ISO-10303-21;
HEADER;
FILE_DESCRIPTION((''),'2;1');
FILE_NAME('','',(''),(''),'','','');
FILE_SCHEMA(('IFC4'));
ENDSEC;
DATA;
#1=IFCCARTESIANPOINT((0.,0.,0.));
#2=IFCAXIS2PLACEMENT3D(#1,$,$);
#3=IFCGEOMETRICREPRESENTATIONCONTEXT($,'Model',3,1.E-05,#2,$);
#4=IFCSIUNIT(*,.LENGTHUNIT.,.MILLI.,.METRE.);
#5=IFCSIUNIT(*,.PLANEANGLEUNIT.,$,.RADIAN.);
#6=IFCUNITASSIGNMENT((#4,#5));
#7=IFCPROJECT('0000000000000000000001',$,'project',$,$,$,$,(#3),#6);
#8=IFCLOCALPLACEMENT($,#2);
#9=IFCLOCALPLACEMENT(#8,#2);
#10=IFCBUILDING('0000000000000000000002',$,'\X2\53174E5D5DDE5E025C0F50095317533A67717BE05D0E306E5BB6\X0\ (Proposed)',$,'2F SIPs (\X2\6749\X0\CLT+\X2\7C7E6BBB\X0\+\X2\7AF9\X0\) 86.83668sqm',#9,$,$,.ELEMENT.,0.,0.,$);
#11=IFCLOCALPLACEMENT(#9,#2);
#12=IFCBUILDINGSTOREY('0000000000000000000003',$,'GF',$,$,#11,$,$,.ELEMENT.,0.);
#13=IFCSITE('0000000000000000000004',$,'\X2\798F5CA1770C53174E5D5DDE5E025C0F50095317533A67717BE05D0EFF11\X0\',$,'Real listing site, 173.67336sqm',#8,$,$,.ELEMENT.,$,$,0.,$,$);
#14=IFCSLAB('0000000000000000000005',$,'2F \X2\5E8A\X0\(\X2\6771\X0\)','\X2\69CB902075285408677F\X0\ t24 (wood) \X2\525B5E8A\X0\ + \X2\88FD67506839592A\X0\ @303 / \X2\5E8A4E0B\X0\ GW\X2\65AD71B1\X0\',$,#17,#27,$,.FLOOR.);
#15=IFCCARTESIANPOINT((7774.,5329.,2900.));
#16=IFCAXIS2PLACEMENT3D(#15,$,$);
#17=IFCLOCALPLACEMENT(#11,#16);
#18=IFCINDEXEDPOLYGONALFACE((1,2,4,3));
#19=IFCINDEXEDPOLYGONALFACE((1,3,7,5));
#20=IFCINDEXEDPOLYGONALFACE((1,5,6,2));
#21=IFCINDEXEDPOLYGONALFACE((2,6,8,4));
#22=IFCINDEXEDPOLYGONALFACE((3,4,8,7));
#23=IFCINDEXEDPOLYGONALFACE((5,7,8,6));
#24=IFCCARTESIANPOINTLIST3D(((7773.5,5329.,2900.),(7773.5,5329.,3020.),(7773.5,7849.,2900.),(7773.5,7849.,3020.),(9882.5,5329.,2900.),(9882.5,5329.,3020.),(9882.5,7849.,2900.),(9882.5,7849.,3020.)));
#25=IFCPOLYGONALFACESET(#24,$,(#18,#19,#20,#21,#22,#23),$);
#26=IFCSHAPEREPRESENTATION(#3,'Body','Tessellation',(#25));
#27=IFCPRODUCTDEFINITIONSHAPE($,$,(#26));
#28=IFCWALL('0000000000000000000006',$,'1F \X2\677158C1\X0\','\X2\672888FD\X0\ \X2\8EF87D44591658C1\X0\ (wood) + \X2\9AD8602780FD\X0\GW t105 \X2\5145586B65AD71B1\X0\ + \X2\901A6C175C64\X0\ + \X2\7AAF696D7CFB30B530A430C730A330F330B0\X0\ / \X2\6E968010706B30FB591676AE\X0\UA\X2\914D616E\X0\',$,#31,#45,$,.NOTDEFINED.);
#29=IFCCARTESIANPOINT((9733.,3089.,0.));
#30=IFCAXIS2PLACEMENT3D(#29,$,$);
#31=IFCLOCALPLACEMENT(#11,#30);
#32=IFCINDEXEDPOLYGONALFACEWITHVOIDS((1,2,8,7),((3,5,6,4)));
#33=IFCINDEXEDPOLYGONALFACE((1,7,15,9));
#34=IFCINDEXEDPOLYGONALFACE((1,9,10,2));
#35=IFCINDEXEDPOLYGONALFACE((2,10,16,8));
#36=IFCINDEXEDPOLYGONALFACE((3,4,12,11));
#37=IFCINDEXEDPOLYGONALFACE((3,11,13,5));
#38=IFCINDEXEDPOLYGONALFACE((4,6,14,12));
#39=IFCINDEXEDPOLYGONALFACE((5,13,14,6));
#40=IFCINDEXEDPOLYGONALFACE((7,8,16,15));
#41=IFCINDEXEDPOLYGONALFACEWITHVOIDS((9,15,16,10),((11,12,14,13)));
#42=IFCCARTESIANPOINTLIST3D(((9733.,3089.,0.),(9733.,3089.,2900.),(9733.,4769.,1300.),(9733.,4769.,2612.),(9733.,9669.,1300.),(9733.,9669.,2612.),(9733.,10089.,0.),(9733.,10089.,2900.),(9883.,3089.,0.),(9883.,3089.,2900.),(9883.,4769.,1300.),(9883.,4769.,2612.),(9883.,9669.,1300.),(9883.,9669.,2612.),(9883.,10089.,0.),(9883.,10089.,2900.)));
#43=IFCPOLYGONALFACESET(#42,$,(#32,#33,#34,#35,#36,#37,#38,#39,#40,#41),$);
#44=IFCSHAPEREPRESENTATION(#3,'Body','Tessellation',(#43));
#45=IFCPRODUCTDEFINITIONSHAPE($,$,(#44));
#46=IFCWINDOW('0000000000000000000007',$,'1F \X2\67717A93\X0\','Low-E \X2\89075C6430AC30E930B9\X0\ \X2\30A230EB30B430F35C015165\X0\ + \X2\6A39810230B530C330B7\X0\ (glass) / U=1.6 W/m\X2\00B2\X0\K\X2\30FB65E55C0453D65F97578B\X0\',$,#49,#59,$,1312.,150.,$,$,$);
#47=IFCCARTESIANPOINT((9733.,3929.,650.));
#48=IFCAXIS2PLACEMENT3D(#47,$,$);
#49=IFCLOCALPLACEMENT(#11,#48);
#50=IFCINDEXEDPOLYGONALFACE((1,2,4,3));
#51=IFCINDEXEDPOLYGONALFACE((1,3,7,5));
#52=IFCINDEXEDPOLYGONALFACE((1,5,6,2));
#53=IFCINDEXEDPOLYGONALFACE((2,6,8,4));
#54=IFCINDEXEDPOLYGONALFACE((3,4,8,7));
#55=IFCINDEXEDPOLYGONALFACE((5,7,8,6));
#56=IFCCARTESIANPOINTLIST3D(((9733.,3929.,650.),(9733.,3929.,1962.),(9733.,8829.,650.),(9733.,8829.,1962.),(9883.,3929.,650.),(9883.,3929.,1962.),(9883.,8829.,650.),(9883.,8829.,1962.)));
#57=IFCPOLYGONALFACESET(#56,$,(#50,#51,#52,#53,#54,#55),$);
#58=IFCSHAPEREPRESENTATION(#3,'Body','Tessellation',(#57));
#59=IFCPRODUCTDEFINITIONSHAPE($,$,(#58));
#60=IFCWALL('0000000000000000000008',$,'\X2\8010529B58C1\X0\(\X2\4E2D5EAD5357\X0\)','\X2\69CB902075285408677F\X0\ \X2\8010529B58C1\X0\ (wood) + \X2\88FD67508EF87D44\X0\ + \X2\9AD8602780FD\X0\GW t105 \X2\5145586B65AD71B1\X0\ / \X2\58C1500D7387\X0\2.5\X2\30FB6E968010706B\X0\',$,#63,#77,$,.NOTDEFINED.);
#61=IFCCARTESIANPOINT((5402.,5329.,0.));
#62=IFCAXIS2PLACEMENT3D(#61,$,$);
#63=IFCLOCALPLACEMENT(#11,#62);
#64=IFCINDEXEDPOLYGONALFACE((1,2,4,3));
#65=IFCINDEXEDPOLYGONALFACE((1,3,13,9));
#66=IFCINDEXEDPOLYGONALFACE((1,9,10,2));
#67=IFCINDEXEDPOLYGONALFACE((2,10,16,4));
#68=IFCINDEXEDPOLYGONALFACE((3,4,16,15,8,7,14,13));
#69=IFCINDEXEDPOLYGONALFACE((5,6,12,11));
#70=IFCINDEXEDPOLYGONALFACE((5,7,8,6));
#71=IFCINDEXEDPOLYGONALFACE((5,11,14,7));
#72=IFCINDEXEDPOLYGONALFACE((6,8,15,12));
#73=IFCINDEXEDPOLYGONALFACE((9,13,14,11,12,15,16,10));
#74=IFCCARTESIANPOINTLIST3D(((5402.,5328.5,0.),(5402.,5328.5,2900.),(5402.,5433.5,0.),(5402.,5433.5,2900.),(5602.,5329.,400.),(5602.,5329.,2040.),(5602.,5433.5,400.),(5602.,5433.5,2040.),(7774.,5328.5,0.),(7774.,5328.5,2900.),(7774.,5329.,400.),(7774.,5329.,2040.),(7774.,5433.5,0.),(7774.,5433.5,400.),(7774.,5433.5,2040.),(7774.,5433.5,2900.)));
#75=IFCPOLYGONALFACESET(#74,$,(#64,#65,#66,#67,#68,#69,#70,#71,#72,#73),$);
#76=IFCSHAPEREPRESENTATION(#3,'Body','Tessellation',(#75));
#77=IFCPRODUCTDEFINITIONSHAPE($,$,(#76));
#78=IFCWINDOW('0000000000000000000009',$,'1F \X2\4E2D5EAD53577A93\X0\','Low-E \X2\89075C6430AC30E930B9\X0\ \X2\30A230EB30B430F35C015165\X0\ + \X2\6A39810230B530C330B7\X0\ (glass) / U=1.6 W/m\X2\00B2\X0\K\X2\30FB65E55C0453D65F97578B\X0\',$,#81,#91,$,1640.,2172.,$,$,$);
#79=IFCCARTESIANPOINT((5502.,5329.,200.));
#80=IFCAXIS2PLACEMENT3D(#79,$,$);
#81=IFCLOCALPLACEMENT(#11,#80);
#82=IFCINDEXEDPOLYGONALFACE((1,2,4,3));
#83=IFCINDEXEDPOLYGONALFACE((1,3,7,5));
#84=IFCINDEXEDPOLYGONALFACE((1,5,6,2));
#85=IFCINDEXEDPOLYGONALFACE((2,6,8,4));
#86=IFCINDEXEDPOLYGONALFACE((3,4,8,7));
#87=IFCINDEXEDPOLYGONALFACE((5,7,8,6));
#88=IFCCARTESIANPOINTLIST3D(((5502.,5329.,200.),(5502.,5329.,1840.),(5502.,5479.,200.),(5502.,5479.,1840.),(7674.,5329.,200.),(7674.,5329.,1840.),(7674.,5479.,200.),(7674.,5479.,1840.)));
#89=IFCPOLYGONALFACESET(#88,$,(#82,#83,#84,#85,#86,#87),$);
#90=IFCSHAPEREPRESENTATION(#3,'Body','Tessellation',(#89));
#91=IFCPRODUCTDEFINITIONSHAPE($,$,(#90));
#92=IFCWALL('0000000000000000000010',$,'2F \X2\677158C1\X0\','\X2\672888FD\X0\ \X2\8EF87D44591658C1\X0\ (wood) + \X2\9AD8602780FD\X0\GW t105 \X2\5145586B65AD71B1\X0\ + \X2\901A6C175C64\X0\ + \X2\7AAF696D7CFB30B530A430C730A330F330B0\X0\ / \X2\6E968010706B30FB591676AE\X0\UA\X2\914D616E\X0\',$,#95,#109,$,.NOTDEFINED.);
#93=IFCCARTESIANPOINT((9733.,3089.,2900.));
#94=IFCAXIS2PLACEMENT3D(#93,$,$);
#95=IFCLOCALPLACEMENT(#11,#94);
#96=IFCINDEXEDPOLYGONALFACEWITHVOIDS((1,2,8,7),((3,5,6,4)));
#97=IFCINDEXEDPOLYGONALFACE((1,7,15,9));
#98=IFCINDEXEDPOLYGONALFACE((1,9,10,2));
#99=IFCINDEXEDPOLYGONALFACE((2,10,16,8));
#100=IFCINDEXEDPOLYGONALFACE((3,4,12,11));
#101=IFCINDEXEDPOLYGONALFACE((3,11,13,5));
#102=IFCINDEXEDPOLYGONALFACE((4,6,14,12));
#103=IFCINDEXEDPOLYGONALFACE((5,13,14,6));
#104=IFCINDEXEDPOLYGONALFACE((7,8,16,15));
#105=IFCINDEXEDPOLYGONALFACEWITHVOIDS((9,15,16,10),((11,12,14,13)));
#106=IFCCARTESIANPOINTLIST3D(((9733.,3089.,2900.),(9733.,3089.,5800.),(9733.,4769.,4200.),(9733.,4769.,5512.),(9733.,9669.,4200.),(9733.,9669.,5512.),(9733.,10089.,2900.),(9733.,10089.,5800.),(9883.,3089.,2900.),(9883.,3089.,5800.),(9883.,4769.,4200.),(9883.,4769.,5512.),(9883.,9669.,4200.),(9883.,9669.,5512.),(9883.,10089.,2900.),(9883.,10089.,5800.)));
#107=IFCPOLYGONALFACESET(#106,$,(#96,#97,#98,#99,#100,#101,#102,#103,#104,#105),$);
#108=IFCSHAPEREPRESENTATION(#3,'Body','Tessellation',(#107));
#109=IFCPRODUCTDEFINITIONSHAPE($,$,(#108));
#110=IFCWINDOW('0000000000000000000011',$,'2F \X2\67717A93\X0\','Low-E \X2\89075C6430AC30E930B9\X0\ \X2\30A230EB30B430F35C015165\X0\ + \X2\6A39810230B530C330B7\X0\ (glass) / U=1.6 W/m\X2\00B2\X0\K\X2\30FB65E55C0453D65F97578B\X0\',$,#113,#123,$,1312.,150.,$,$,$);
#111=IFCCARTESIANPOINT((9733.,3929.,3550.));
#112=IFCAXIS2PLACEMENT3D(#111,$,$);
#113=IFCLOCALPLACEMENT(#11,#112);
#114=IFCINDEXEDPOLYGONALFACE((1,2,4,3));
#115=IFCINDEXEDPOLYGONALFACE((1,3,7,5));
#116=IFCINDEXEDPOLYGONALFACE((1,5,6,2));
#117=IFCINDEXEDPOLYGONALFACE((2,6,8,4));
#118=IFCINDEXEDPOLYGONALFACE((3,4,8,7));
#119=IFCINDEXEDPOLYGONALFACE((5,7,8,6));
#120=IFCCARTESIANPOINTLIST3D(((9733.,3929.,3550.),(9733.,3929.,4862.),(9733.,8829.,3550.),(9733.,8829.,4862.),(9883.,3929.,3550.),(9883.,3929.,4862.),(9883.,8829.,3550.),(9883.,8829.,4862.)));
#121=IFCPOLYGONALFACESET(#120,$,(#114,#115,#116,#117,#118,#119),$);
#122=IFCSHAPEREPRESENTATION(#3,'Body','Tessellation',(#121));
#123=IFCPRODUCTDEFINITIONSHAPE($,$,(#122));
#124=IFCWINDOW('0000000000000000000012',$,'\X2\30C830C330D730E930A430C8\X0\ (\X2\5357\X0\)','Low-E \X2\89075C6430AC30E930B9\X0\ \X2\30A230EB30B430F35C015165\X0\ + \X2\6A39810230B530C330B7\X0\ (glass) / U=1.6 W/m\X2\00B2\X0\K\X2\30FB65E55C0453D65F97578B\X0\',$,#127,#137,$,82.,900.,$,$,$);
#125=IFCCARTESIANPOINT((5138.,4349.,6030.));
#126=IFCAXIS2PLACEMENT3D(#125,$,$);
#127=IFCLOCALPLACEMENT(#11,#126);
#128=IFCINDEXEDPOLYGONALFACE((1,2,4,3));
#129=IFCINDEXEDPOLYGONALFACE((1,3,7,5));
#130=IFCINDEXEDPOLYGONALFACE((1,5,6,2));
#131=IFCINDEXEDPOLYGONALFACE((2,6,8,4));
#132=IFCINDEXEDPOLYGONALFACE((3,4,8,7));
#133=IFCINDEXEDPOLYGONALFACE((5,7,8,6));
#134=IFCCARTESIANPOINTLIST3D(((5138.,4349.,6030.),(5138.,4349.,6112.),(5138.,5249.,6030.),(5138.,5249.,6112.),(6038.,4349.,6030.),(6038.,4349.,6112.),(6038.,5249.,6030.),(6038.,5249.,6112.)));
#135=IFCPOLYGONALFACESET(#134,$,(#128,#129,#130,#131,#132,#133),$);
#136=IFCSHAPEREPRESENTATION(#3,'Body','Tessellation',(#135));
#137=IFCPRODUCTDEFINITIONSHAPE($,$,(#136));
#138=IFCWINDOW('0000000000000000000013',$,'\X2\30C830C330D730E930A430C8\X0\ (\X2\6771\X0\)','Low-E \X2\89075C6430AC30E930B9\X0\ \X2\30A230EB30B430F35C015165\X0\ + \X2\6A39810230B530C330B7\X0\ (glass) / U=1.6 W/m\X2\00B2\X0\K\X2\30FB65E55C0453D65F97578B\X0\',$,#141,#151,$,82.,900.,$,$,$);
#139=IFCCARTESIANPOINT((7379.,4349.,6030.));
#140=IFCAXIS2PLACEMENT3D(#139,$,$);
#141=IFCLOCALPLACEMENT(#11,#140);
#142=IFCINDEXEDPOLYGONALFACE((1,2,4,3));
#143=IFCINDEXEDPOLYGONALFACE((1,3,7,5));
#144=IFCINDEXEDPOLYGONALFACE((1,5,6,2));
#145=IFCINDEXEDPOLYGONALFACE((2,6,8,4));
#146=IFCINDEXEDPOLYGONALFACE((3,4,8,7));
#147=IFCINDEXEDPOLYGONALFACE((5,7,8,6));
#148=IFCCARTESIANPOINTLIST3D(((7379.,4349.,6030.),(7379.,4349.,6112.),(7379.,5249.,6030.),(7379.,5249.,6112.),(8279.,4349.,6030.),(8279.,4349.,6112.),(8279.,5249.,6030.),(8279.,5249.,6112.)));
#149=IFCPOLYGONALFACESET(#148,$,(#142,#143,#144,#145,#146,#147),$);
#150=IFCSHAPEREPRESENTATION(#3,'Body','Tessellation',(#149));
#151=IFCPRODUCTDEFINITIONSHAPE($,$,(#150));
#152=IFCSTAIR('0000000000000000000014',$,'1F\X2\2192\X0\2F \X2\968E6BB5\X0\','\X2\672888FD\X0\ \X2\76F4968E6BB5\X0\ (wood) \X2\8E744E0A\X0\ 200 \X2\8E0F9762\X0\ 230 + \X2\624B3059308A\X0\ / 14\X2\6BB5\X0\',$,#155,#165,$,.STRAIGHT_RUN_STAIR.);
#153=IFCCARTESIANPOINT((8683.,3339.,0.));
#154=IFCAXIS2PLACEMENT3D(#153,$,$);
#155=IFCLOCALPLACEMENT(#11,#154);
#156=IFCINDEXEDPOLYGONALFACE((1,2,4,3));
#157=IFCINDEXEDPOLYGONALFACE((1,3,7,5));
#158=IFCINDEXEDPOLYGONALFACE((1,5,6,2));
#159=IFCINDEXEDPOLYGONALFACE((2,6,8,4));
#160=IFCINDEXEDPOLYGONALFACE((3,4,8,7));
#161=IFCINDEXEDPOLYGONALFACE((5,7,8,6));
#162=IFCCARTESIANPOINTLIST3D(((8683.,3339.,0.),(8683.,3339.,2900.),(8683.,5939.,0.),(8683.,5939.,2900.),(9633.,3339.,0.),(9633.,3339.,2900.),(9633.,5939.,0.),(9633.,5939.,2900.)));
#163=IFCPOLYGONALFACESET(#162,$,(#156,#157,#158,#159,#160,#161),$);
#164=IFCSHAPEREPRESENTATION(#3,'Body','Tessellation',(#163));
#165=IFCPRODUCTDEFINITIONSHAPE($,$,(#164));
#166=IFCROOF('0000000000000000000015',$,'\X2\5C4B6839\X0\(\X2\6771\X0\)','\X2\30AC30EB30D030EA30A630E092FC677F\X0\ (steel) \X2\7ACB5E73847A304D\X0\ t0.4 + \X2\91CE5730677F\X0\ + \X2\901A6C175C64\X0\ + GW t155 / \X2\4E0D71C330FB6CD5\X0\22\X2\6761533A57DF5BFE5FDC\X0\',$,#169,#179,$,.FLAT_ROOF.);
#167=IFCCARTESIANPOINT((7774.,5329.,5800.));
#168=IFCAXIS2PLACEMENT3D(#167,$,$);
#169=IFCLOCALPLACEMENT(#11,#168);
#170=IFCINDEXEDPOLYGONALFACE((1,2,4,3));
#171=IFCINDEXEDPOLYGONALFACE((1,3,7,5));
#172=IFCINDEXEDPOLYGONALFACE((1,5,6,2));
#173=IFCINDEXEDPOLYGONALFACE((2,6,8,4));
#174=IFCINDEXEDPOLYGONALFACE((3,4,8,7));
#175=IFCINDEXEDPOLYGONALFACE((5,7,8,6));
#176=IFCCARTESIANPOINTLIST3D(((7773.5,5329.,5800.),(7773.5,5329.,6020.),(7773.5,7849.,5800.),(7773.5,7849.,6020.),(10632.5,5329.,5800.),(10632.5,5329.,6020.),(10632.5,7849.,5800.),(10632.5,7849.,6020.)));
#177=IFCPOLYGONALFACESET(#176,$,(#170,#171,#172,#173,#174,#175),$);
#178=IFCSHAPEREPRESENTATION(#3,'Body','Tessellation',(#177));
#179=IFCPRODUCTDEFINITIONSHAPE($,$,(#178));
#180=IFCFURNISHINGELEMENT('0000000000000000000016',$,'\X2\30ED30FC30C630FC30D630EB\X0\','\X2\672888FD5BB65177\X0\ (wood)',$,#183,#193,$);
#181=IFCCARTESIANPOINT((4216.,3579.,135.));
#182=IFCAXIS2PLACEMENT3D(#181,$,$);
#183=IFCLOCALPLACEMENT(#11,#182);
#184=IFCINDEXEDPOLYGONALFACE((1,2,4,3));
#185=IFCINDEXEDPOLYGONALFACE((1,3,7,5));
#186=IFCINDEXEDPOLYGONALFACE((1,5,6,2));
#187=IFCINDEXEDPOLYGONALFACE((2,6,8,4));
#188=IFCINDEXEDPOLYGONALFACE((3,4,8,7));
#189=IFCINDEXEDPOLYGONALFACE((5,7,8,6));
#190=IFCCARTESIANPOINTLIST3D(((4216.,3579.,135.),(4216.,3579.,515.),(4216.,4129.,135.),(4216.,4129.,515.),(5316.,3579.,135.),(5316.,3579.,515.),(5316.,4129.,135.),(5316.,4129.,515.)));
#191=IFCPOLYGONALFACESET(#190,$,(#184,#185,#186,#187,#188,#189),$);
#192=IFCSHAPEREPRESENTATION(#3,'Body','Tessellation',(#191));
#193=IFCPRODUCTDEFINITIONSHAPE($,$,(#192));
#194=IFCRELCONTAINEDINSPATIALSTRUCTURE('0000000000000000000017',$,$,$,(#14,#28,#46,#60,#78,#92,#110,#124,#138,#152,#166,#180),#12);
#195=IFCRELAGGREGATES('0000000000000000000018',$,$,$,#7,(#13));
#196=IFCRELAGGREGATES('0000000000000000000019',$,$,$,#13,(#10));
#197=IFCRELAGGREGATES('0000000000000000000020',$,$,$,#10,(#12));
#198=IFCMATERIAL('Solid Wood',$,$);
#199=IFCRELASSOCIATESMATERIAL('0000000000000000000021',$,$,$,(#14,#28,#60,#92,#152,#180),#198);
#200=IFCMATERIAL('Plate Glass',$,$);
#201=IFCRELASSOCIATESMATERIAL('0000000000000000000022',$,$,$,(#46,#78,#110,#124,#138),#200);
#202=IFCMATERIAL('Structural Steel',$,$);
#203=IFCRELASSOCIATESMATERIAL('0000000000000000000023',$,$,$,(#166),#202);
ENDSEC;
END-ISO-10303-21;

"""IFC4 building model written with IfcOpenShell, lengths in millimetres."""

from ifc_helpers import new_model, si_unit, frame, frame_2d, origin, place, context, project, spatial, rectangle, extrude, material, element, fill, save


model = new_model("IFC4")

# Units and contexts
model_context = context("Model", 3, precision=1e-05, world=origin())
ifc_project = project(units=[si_unit("LENGTHUNIT", "METRE", prefix="MILLI"), si_unit("PLANEANGLEUNIT", "RADIAN")], contexts=[model_context])

# Site, building, storey
site_placement = place(None, origin())
site = spatial("IfcSite", under=ifc_project, at=site_placement, Name="福岡県北九州市小倉北区東篠崎１", ObjectType="Real listing site, 173.67336sqm", CompositionType="ELEMENT", RefElevation=0.0)
building_placement = place(site_placement, origin())
building = spatial("IfcBuilding", under=site, at=building_placement, Name="北九州市小倉北区東篠崎の家 (Proposed)", ObjectType="2F SIPs (杉CLT+籾殻+竹) 86.83668sqm", CompositionType="ELEMENT", ElevationOfRefHeight=0.0, ElevationOfTerrain=0.0)
storey_placement = place(building_placement, origin())
storey = spatial("IfcBuildingStorey", under=building, at=storey_placement, Name="GF", CompositionType="ELEMENT", Elevation=0.0)

# Slab
ifc_material_1 = material(Name="Solid Wood")
slab_1_placement = place(storey_placement, frame((7774.0, 5329.0, 2900.0)))
element("IfcSlab", 1, at=slab_1_placement, inside=storey, material=ifc_material_1, Name="2F 床(東)", Description="構造用合板 t24 (wood) 剛床 + 製材根太 @303 / 床下 GW断熱", PredefinedType="FLOOR", context=model_context, shape_type="SweptSolid", body=[
    extrude(rectangle(XDim=2109.0, YDim=2520.0, at=frame_2d((1054.0, 1260.0))), frame((7774.0, 5329.0, 2900.0)), (0.0, 0.0, 1.0), 120.0),
])

# Walls, openings, windows
wall_1_placement = place(storey_placement, frame((9733.0, 3089.0, 0.0)))
wall_1 = element("IfcWall", 2, at=wall_1_placement, inside=storey, material=ifc_material_1, Name="1F 東壁", Description="木製 軸組外壁 (wood) + 高性能GW t105 充填断熱 + 通気層 + 窯業系サイディング / 準耐火・外皮UA配慮", PredefinedType="NOTDEFINED", context=model_context, shape_type="SweptSolid", body=[
    extrude(rectangle(XDim=150.0, YDim=7000.0, at=frame_2d((75.0, 3500.0))), frame((9733.0, 3089.0, 0.0)), (0.0, 0.0, 1.0), 2900.0),
])
opening_1_placement = place(storey_placement, frame((9733.0, 3929.0, 650.0)))
opening_1 = element("IfcOpeningElement", 3, at=opening_1_placement, cuts=wall_1, PredefinedType="NOTDEFINED", context=model_context, shape_type="SweptSolid", body=[
    extrude(rectangle(XDim=150.0, YDim=4900.0, at=frame_2d((75.0, 2450.0))), frame((9733.0, 3929.0, 650.0)), (0.0, 0.0, 1.0), 1312.0),
])
ifc_material_2 = material(Name="Plate Glass")
window_1_placement = place(storey_placement, frame((9733.0, 3929.0, 650.0)))
window_1 = element("IfcWindow", 4, at=window_1_placement, inside=storey, material=ifc_material_2, Name="1F 東窓", Description="Low-E 複層ガラス アルゴン封入 + 樹脂サッシ (glass) / U=1.6 W/m²K・日射取得型", OverallHeight=1312.0, OverallWidth=150.0, context=model_context, shape_type="SweptSolid", body=[
    extrude(rectangle(XDim=150.0, YDim=4900.0, at=frame_2d((75.0, 2450.0))), frame((9733.0, 3929.0, 650.0)), (0.0, 0.0, 1.0), 1312.0),
])
fill(opening_1, window_1)
wall_2_placement = place(storey_placement, frame((5402.0, 5329.0, 0.0)))
wall_2 = element("IfcWall", 5, at=wall_2_placement, inside=storey, material=ifc_material_1, Name="耐力壁(中庭南)", Description="構造用合板 耐力壁 (wood) + 製材軸組 + 高性能GW t105 充填断熱 / 壁倍率2.5・準耐火", PredefinedType="NOTDEFINED", context=model_context, shape_type="SweptSolid", body=[
    extrude(rectangle(XDim=2372.0, YDim=105.0, at=frame_2d((1186.0, 52.0))), frame((5402.0, 5329.0, 0.0)), (0.0, 0.0, 1.0), 2900.0),
])
opening_2_placement = place(storey_placement, frame((5502.0, 5329.0, 200.0)))
opening_2 = element("IfcOpeningElement", 6, at=opening_2_placement, cuts=wall_2, PredefinedType="NOTDEFINED", context=model_context, shape_type="SweptSolid", body=[
    extrude(rectangle(XDim=2172.0, YDim=150.0, at=frame_2d((1086.0, 75.0))), frame((5502.0, 5329.0, 200.0)), (0.0, 0.0, 1.0), 1640.0),
])
window_2_placement = place(storey_placement, frame((5502.0, 5329.0, 200.0)))
window_2 = element("IfcWindow", 7, at=window_2_placement, inside=storey, material=ifc_material_2, Name="1F 中庭南窓", Description="Low-E 複層ガラス アルゴン封入 + 樹脂サッシ (glass) / U=1.6 W/m²K・日射取得型", OverallHeight=1640.0, OverallWidth=2172.0, context=model_context, shape_type="SweptSolid", body=[
    extrude(rectangle(XDim=2172.0, YDim=150.0, at=frame_2d((1086.0, 75.0))), frame((5502.0, 5329.0, 200.0)), (0.0, 0.0, 1.0), 1640.0),
])
fill(opening_2, window_2)

# Wall, opening, window
wall_3_placement = place(storey_placement, frame((9733.0, 3089.0, 2900.0)))
wall_3 = element("IfcWall", 8, at=wall_3_placement, inside=storey, material=ifc_material_1, Name="2F 東壁", Description="木製 軸組外壁 (wood) + 高性能GW t105 充填断熱 + 通気層 + 窯業系サイディング / 準耐火・外皮UA配慮", PredefinedType="NOTDEFINED", context=model_context, shape_type="SweptSolid", body=[
    extrude(rectangle(XDim=150.0, YDim=7000.0, at=frame_2d((75.0, 3500.0))), frame((9733.0, 3089.0, 2900.0)), (0.0, 0.0, 1.0), 2900.0),
])
opening_3_placement = place(storey_placement, frame((9733.0, 3929.0, 3550.0)))
opening_3 = element("IfcOpeningElement", 9, at=opening_3_placement, cuts=wall_3, PredefinedType="NOTDEFINED", context=model_context, shape_type="SweptSolid", body=[
    extrude(rectangle(XDim=150.0, YDim=4900.0, at=frame_2d((75.0, 2450.0))), frame((9733.0, 3929.0, 3550.0)), (0.0, 0.0, 1.0), 1312.0),
])
window_3_placement = place(storey_placement, frame((9733.0, 3929.0, 3550.0)))
window_3 = element("IfcWindow", 10, at=window_3_placement, inside=storey, material=ifc_material_2, Name="2F 東窓", Description="Low-E 複層ガラス アルゴン封入 + 樹脂サッシ (glass) / U=1.6 W/m²K・日射取得型", OverallHeight=1312.0, OverallWidth=150.0, context=model_context, shape_type="SweptSolid", body=[
    extrude(rectangle(XDim=150.0, YDim=4900.0, at=frame_2d((75.0, 2450.0))), frame((9733.0, 3929.0, 3550.0)), (0.0, 0.0, 1.0), 1312.0),
])
fill(opening_3, window_3)

# Windows
window_4_placement = place(storey_placement, frame((5138.0, 4349.0, 6030.0)))
element("IfcWindow", 11, at=window_4_placement, inside=storey, material=ifc_material_2, Name="トップライト (南)", Description="Low-E 複層ガラス アルゴン封入 + 樹脂サッシ (glass) / U=1.6 W/m²K・日射取得型", OverallHeight=82.0, OverallWidth=900.0, context=model_context, shape_type="SweptSolid", body=[
    extrude(rectangle(XDim=900.0, YDim=900.0, at=frame_2d((450.0, 450.0))), frame((5138.0, 4349.0, 6030.0)), (0.0, 0.0, 1.0), 82.0),
])
window_5_placement = place(storey_placement, frame((7379.0, 4349.0, 6030.0)))
element("IfcWindow", 12, at=window_5_placement, inside=storey, material=ifc_material_2, Name="トップライト (東)", Description="Low-E 複層ガラス アルゴン封入 + 樹脂サッシ (glass) / U=1.6 W/m²K・日射取得型", OverallHeight=82.0, OverallWidth=900.0, context=model_context, shape_type="SweptSolid", body=[
    extrude(rectangle(XDim=900.0, YDim=900.0, at=frame_2d((450.0, 450.0))), frame((7379.0, 4349.0, 6030.0)), (0.0, 0.0, 1.0), 82.0),
])

# Stair
stair_placement = place(storey_placement, frame((8683.0, 3339.0, 0.0)))
element("IfcStair", 13, at=stair_placement, inside=storey, material=ifc_material_1, Name="1F→2F 階段", Description="木製 直階段 (wood) 蹴上 200 踏面 230 + 手すり / 14段", PredefinedType="STRAIGHT_RUN_STAIR", context=model_context, shape_type="SweptSolid", body=[
    extrude(rectangle(XDim=950.0, YDim=2600.0, at=frame_2d((475.0, 1300.0))), frame((8683.0, 3339.0, 0.0)), (0.0, 0.0, 1.0), 2900.0),
])

# Roof
ifc_material_3 = material(Name="Structural Steel")
roof_placement = place(storey_placement, frame((7774.0, 5329.0, 5800.0)))
element("IfcRoof", 14, at=roof_placement, inside=storey, material=ifc_material_3, Name="屋根(東)", Description="ガルバリウム鋼板 (steel) 立平葺き t0.4 + 野地板 + 通気層 + GW t155 / 不燃・法22条区域対応", PredefinedType="FLAT_ROOF", context=model_context, shape_type="SweptSolid", body=[
    extrude(rectangle(XDim=2859.0, YDim=2520.0, at=frame_2d((1429.0, 1260.0))), frame((7774.0, 5329.0, 5800.0)), (0.0, 0.0, 1.0), 220.0),
])

# Furnishing element
furnishing_1_placement = place(storey_placement, frame((4216.0, 3579.0, 135.0)))
element("IfcFurnishingElement", 15, at=furnishing_1_placement, inside=storey, material=ifc_material_1, Name="ローテーブル", Description="木製家具 (wood)", context=model_context, shape_type="SweptSolid", body=[
    extrude(rectangle(XDim=1100.0, YDim=550.0, at=frame_2d((550.0, 275.0))), frame((4216.0, 3579.0, 135.0)), (0.0, 0.0, 1.0), 380.0),
])

save(model, "model.ifc")
